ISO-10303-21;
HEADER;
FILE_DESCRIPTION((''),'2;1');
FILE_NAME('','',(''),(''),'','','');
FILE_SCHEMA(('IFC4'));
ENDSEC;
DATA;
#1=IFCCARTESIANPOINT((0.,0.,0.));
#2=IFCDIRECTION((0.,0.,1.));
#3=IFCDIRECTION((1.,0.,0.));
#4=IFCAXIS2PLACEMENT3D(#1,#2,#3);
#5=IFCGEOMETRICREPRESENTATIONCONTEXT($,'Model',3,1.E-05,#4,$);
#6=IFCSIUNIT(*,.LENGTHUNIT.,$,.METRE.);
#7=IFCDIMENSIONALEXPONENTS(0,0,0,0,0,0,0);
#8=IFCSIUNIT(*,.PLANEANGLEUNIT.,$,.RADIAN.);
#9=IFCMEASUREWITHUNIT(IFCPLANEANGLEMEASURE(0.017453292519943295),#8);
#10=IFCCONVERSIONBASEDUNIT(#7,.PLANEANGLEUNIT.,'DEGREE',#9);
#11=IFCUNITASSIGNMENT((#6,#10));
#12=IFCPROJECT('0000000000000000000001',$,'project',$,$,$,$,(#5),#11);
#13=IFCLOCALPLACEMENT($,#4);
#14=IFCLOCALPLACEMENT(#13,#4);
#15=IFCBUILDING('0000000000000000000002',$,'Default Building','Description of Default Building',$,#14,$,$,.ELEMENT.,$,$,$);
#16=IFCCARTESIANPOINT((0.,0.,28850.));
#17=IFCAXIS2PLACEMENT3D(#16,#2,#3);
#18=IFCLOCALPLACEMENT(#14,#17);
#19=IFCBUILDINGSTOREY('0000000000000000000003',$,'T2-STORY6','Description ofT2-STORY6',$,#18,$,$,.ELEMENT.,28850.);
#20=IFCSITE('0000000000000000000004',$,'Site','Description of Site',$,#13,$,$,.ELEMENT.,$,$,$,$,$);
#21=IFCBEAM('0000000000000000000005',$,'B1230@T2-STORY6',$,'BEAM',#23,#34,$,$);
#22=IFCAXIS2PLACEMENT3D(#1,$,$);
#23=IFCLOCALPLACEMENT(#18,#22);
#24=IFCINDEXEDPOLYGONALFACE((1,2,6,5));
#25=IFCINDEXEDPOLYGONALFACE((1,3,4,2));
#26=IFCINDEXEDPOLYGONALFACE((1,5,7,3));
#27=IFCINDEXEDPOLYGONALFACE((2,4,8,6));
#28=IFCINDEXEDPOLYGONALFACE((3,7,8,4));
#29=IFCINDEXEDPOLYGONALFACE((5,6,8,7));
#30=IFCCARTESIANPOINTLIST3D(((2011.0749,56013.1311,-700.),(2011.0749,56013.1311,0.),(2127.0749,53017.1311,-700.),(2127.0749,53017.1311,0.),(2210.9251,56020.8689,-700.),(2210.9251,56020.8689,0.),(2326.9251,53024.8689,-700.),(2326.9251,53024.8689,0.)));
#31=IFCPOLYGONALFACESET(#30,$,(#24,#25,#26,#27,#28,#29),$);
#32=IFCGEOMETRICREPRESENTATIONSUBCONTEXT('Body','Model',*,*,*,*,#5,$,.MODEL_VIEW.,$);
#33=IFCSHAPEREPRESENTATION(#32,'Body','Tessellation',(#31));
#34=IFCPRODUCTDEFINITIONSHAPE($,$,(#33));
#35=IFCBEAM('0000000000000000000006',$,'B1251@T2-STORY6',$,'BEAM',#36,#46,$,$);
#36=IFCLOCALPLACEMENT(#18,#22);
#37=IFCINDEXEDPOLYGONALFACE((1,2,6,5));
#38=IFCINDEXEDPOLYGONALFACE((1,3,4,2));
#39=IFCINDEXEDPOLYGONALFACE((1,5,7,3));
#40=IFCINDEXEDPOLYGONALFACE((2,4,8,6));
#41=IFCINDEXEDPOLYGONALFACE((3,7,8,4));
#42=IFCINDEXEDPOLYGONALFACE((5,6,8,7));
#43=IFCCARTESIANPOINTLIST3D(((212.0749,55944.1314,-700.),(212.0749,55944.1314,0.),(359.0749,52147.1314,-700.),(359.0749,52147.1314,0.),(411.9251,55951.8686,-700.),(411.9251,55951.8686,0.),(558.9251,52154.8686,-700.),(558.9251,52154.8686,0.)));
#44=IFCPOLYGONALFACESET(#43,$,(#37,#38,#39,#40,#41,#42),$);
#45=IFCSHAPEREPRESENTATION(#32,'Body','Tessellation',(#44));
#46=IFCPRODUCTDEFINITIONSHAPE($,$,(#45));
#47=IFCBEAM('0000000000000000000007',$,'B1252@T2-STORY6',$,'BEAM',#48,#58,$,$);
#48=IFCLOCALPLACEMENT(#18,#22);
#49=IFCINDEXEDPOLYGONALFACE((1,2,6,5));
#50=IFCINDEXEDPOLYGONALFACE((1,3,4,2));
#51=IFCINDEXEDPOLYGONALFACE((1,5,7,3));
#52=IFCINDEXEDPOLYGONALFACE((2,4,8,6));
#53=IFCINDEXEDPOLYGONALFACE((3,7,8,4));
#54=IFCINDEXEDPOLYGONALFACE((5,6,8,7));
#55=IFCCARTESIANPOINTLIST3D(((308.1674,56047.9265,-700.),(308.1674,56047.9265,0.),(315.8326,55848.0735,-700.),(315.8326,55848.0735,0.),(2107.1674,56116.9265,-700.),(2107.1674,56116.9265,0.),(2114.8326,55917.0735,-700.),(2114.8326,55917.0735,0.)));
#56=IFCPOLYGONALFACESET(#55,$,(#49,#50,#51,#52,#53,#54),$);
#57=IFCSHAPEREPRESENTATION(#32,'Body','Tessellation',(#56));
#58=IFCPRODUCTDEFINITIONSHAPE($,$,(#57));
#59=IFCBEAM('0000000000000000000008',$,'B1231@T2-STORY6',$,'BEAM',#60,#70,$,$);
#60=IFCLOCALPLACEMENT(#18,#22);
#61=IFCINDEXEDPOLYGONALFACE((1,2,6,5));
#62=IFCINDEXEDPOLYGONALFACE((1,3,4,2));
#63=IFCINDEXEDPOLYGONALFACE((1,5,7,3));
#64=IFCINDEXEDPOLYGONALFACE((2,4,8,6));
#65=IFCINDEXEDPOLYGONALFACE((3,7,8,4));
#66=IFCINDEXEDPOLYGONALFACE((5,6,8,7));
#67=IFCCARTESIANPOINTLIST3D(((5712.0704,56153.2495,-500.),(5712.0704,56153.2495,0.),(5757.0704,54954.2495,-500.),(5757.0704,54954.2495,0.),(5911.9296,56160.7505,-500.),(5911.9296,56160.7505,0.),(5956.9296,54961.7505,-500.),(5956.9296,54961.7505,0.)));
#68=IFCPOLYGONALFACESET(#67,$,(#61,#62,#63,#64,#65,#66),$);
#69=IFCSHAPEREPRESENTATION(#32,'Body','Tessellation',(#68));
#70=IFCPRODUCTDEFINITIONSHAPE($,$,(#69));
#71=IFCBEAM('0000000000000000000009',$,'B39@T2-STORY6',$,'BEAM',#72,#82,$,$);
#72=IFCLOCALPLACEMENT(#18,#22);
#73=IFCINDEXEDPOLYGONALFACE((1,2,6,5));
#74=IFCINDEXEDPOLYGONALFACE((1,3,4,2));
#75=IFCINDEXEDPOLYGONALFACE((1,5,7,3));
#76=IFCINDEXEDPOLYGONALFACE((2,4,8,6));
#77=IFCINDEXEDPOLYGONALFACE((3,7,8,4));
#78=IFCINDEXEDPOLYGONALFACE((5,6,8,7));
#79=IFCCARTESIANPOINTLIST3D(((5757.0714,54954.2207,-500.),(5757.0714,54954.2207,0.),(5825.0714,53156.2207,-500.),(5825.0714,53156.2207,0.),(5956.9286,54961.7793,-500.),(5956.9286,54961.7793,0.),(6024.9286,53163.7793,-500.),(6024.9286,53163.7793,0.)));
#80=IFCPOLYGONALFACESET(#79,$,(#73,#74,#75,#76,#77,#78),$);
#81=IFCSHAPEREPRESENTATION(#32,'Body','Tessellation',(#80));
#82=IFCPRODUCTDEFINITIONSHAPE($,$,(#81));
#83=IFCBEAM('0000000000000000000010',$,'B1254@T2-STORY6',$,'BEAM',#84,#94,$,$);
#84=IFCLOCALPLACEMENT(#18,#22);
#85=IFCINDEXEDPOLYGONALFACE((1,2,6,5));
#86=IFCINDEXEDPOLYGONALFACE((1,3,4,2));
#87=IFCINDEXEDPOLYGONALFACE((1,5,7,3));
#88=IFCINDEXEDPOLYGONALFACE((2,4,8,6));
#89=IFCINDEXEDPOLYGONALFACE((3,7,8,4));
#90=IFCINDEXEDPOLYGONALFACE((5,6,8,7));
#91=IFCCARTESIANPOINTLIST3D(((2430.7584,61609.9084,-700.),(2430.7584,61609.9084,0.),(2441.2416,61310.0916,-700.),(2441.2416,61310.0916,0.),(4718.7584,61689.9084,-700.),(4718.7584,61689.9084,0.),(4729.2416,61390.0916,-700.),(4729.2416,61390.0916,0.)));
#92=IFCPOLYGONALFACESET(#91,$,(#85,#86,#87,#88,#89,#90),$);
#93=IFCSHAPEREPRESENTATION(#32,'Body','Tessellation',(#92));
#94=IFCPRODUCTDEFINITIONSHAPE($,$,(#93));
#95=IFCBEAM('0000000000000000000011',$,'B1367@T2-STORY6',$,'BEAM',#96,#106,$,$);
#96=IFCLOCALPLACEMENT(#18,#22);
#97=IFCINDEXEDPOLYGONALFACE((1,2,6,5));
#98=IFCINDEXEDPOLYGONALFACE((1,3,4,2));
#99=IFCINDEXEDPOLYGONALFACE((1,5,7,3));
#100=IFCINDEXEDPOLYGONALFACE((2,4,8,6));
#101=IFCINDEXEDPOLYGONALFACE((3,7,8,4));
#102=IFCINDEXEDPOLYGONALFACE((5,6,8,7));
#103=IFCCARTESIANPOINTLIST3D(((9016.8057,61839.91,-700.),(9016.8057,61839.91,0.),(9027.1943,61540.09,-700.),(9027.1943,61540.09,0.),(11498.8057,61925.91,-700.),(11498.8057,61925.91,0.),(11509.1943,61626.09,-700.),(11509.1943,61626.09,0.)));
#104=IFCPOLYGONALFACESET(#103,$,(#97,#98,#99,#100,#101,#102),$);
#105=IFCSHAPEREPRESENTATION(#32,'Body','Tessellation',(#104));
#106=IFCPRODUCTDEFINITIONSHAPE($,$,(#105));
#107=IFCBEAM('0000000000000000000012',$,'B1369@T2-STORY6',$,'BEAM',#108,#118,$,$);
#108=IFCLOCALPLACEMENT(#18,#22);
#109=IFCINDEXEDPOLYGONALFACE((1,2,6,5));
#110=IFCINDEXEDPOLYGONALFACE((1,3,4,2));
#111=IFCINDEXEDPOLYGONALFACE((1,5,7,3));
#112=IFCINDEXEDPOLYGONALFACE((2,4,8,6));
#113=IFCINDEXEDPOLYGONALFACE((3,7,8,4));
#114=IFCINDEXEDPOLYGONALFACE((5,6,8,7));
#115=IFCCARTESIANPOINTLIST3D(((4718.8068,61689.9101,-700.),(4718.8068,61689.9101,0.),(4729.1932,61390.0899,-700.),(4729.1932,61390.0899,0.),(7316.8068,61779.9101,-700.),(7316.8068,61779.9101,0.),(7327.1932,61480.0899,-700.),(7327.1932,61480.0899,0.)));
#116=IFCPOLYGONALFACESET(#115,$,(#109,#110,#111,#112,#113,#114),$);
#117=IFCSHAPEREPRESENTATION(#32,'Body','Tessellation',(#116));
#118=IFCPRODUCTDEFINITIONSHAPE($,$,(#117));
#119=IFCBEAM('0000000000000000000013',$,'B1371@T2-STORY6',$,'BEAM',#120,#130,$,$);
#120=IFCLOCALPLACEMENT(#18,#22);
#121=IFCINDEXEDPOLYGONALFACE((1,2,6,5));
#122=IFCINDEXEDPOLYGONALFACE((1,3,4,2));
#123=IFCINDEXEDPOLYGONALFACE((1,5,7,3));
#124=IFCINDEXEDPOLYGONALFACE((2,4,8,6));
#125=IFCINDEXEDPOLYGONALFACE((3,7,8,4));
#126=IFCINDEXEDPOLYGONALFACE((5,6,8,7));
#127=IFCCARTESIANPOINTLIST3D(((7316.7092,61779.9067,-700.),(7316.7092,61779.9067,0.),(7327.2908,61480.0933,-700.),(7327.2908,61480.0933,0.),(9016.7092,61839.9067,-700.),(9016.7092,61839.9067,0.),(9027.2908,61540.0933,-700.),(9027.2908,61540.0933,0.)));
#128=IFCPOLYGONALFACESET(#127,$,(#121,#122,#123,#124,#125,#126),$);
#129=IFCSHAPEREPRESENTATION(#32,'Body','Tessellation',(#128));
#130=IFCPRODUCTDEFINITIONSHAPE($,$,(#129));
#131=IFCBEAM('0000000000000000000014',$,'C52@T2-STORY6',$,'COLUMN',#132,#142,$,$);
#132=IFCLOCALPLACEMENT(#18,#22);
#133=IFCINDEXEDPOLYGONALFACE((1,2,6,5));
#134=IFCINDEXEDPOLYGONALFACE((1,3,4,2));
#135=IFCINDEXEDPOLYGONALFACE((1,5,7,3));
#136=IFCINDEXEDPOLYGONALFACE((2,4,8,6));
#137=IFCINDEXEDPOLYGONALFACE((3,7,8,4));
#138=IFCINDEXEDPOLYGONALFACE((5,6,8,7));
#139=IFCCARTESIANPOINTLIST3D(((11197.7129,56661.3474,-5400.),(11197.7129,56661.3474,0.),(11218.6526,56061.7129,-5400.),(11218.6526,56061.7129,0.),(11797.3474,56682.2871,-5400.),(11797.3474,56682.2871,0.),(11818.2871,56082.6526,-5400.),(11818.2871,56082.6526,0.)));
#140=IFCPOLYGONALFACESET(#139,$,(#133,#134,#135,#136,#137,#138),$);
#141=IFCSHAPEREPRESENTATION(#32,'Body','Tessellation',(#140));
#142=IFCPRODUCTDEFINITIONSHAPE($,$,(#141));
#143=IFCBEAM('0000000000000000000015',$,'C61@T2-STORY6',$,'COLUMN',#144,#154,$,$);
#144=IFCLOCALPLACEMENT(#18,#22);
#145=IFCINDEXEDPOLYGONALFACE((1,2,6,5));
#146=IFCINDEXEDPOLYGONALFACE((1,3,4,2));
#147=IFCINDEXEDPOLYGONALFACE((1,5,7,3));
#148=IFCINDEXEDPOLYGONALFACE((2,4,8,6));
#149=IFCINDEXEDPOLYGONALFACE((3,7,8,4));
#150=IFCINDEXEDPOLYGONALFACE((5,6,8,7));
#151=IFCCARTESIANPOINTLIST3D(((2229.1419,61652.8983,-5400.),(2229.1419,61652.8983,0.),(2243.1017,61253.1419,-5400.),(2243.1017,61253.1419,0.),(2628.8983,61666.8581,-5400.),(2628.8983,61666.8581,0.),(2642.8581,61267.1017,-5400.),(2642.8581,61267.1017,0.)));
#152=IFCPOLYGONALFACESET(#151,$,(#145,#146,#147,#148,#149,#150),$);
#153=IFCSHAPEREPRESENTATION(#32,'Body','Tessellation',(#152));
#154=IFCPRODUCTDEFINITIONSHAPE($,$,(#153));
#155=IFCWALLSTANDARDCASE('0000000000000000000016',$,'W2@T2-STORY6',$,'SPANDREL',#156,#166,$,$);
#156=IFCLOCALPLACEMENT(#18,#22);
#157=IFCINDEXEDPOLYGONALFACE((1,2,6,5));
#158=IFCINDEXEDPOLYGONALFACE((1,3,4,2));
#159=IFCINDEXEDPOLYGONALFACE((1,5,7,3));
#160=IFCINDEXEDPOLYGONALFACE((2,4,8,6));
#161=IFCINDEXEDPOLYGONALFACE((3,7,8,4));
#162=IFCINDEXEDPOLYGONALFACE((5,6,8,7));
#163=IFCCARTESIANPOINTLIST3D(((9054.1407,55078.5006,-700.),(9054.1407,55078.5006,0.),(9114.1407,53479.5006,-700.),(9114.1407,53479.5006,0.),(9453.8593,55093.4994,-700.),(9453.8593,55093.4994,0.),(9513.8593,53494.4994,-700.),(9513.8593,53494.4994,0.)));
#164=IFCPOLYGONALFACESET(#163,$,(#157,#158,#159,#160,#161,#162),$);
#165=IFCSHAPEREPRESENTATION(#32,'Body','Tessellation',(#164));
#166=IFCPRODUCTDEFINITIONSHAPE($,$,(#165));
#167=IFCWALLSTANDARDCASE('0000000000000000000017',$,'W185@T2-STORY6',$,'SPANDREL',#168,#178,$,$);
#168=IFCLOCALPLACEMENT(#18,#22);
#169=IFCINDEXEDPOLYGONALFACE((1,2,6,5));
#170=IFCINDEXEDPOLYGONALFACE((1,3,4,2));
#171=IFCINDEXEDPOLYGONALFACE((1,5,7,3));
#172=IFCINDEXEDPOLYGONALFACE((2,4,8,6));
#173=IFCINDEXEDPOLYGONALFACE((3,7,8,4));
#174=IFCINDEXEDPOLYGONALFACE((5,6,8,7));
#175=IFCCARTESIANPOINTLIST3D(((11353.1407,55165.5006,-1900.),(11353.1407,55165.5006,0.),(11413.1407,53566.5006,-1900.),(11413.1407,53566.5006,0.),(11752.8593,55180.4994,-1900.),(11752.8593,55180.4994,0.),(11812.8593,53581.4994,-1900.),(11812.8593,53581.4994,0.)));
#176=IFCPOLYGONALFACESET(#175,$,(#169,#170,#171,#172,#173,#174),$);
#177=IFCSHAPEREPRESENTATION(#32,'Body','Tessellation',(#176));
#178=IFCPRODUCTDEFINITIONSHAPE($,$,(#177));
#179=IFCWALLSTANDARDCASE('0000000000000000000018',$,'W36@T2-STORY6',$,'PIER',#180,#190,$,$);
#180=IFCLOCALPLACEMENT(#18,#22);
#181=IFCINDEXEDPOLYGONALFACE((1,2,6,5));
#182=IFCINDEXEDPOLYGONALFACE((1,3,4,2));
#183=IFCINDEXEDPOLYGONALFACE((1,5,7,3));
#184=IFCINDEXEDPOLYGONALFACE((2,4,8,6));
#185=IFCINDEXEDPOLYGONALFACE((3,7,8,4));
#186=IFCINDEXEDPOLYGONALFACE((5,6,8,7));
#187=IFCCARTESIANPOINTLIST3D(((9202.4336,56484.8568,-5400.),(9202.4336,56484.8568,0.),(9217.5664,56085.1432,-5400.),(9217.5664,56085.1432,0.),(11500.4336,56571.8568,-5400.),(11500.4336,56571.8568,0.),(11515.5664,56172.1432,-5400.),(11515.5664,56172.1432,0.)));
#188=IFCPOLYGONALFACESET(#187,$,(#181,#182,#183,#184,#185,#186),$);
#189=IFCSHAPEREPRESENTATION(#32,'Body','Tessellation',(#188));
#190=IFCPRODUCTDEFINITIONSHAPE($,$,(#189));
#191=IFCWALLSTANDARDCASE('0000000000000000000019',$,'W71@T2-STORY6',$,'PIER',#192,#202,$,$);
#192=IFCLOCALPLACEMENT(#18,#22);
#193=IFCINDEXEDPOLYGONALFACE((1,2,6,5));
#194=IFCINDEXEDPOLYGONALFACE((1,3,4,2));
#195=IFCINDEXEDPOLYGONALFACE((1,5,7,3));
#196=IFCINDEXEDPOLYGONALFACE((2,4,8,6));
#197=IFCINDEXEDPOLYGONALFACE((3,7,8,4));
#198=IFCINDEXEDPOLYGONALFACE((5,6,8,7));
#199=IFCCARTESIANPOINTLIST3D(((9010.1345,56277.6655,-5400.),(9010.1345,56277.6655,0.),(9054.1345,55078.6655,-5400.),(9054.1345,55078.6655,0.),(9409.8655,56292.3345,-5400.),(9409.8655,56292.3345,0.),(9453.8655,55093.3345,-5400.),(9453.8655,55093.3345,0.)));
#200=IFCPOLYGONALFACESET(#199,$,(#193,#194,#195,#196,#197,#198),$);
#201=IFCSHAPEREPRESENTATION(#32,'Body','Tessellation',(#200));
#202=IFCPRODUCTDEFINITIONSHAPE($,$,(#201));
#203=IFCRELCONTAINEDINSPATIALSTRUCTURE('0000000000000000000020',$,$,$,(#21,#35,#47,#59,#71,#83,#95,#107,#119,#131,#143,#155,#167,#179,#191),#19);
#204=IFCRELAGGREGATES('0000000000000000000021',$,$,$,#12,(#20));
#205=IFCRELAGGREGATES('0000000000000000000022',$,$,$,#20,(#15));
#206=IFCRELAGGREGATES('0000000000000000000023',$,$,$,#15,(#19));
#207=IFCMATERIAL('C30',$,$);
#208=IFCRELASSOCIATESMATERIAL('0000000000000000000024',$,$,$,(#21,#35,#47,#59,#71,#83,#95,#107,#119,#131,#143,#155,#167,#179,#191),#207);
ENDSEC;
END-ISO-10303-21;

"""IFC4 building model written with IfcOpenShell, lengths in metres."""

from ifc_helpers import new_model, entity, si_unit, converted_unit, frame, origin_with_axes, place, context, subcontext, project, spatial, indexed_curve, rectangle, outline, extrude, material, element, save


model = new_model("IFC4")

# Units and contexts
model_context = context("Model", 3, precision=1e-05, world=origin_with_axes())
body_context = subcontext(model_context, "Body", "Model", "MODEL_VIEW")
ifc_project = project(units=[si_unit("LENGTHUNIT", "METRE"), converted_unit("PLANEANGLEUNIT", "DEGREE", entity("IfcPlaneAngleMeasure", 0.017453292519943295), si_unit("PLANEANGLEUNIT", "RADIAN"), dimensions=[0, 0, 0, 0, 0, 0, 0])], contexts=[model_context])

# Site, building, storey
site_placement = place(None, origin_with_axes())
site = spatial("IfcSite", under=ifc_project, at=site_placement, Name="Site", Description="Description of Site", CompositionType="ELEMENT")
building_placement = place(site_placement, origin_with_axes())
building = spatial("IfcBuilding", under=site, at=building_placement, Name="Default Building", Description="Description of Default Building", CompositionType="ELEMENT")
storey_placement = place(building_placement, frame((0.0, 0.0, 28850.0), z_axis=(0.0, 0.0, 1.0), x_axis=(1.0, 0.0, 0.0)))
storey = spatial("IfcBuildingStorey", under=building, at=storey_placement, Name="T2-STORY6", Description="Description ofT2-STORY6", CompositionType="ELEMENT", Elevation=28850.0)

# Beams
ifc_material = material(Name="C30")
beam_1_placement = place(storey_placement, frame((2111.0, 56017.0, -350.0), z_axis=(0.038689, -0.999251, 0.0), x_axis=(0.999251, 0.038689, 0.0)))
element("IfcBeam", 1, at=beam_1_placement, inside=storey, material=ifc_material, Name="B1230@T2-STORY6", ObjectType="BEAM", context=body_context, shape_type="SweptSolid", body=[
    extrude(rectangle(XDim=200.0, YDim=700.0), origin_with_axes(), (0.0, 0.0, 1.0), 2998.2448),
])
beam_2_placement = place(storey_placement, frame((312.0, 55948.0, -350.0), z_axis=(0.038686, -0.999251, 0.0), x_axis=(0.999251, 0.038686, 0.0)))
element("IfcBeam", 2, at=beam_2_placement, inside=storey, material=ifc_material, Name="B1251@T2-STORY6", ObjectType="BEAM", context=body_context, shape_type="SweptSolid", body=[
    extrude(rectangle(XDim=200.0, YDim=700.0), origin_with_axes(), (0.0, 0.0, 1.0), 3799.8445),
])
beam_3_placement = place(storey_placement, frame((312.0, 55948.0, -350.0), z_axis=(0.999265, 0.038326, 0.0), x_axis=(-0.038326, 0.999265, 0.0)))
element("IfcBeam", 3, at=beam_3_placement, inside=storey, material=ifc_material, Name="B1252@T2-STORY6", ObjectType="BEAM", context=body_context, shape_type="SweptSolid", body=[
    extrude(rectangle(XDim=200.0, YDim=700.0), origin_with_axes(), (0.0, 0.0, 1.0), 1800.3227),
])
beam_4_placement = place(storey_placement, frame((5812.0, 56157.0, -250.0), z_axis=(0.037505, -0.999296, 0.0), x_axis=(0.999296, 0.037505, 0.0)))
element("IfcBeam", 4, at=beam_4_placement, inside=storey, material=ifc_material, Name="B1231@T2-STORY6", ObjectType="BEAM", context=body_context, shape_type="SweptSolid", body=[
    extrude(rectangle(XDim=200.0, YDim=500.0), origin_with_axes(), (0.0, 0.0, 1.0), 1199.8442),
])
beam_5_placement = place(storey_placement, frame((5857.0, 54958.0, -250.0), z_axis=(0.037793, -0.999286, 0.0), x_axis=(0.999286, 0.037793, 0.0)))
element("IfcBeam", 5, at=beam_5_placement, inside=storey, material=ifc_material, Name="B39@T2-STORY6", ObjectType="BEAM", context=body_context, shape_type="SweptSolid", body=[
    extrude(rectangle(XDim=200.0, YDim=500.0), origin_with_axes(), (0.0, 0.0, 1.0), 1799.2854),
])
beam_6_placement = place(storey_placement, frame((2436.0, 61460.0, -350.0), z_axis=(0.999389, 0.034944, 0.0), x_axis=(-0.034944, 0.999389, 0.0)))
element("IfcBeam", 6, at=beam_6_placement, inside=storey, material=ifc_material, Name="B1254@T2-STORY6", ObjectType="BEAM", context=body_context, shape_type="SweptSolid", body=[
    extrude(rectangle(XDim=300.0, YDim=700.0), origin_with_axes(), (0.0, 0.0, 1.0), 2289.3982),
])
beam_7_placement = place(storey_placement, frame((9022.0, 61690.0, -350.0), z_axis=(0.9994, 0.034629, 0.0), x_axis=(-0.034629, 0.9994, 0.0)))
element("IfcBeam", 7, at=beam_7_placement, inside=storey, material=ifc_material, Name="B1367@T2-STORY6", ObjectType="BEAM", context=body_context, shape_type="SweptSolid", body=[
    extrude(rectangle(XDim=300.0, YDim=700.0), origin_with_axes(), (0.0, 0.0, 1.0), 2483.4895),
])
beam_8_placement = place(storey_placement, frame((4724.0, 61540.0, -350.0), z_axis=(0.999401, 0.034621, 0.0), x_axis=(-0.034621, 0.999401, 0.0)))
element("IfcBeam", 8, at=beam_8_placement, inside=storey, material=ifc_material, Name="B1369@T2-STORY6", ObjectType="BEAM", context=body_context, shape_type="SweptSolid", body=[
    extrude(rectangle(XDim=300.0, YDim=700.0), origin_with_axes(), (0.0, 0.0, 1.0), 2599.5584),
])
beam_9_placement = place(storey_placement, frame((7322.0, 61630.0, -350.0), z_axis=(0.999378, 0.035272, 0.0), x_axis=(-0.035272, 0.999378, 0.0)))
element("IfcBeam", 9, at=beam_9_placement, inside=storey, material=ifc_material, Name="B1371@T2-STORY6", ObjectType="BEAM", context=body_context, shape_type="SweptSolid", body=[
    extrude(rectangle(XDim=300.0, YDim=700.0), origin_with_axes(), (0.0, 0.0, 1.0), 1701.0585),
])
beam_10_placement = place(storey_placement, frame((11508.0, 56372.0, -5400.0), z_axis=(0.0, 0.0, 1.0), x_axis=(-0.999391, -0.034899, 0.0)))
element("IfcBeam", 10, at=beam_10_placement, inside=storey, material=ifc_material, Name="C52@T2-STORY6", ObjectType="COLUMN", context=body_context, shape_type="SweptSolid", body=[
    extrude(rectangle(XDim=600.0, YDim=600.0), origin_with_axes(), (0.0, 0.0, 1.0), 5400.0),
])
beam_11_placement = place(storey_placement, frame((2436.0, 61460.0, -5400.0), z_axis=(0.0, 0.0, 1.0), x_axis=(-0.999391, -0.034899, 0.0)))
element("IfcBeam", 11, at=beam_11_placement, inside=storey, material=ifc_material, Name="C61@T2-STORY6", ObjectType="COLUMN", context=body_context, shape_type="SweptSolid", body=[
    extrude(rectangle(XDim=400.0, YDim=400.0), origin_with_axes(), (0.0, 0.0, 1.0), 5400.0),
])

# Walls
wall_1_placement = place(storey_placement, frame((9254.0, 55086.0, -700.0), z_axis=(0.0, 0.0, 1.0), x_axis=(0.037497, -0.999297, 0.0)))
element("IfcWallStandardCase", 12, at=wall_1_placement, inside=storey, material=ifc_material, Name="W2@T2-STORY6", ObjectType="SPANDREL", context=body_context, shape_type="SweptSolid", body=[
    extrude(outline(indexed_curve([(0.0, -200.0), (0.0, 200.0), (1600.1253, 200.0), (1600.1253, -200.0), (0.0, -200.0)], self_intersect=False)), origin_with_axes(), (0.0, 0.0, 1.0), 700.0),
])
wall_2_placement = place(storey_placement, frame((11553.0, 55173.0, -1900.0), z_axis=(0.0, 0.0, 1.0), x_axis=(0.037497, -0.999297, 0.0)))
element("IfcWallStandardCase", 13, at=wall_2_placement, inside=storey, material=ifc_material, Name="W185@T2-STORY6", ObjectType="SPANDREL", context=body_context, shape_type="SweptSolid", body=[
    extrude(outline(indexed_curve([(0.0, -200.0), (0.0, 200.0), (1600.1253, 200.0), (1600.1253, -200.0), (0.0, -200.0)], self_intersect=False)), origin_with_axes(), (0.0, 0.0, 1.0), 1900.0),
])
wall_3_placement = place(storey_placement, frame((9210.0, 56285.0, -5400.0), z_axis=(0.0, 0.0, 1.0), x_axis=(0.999284, 0.037832, 0.0)))
element("IfcWallStandardCase", 14, at=wall_3_placement, inside=storey, material=ifc_material, Name="W36@T2-STORY6", ObjectType="PIER", context=body_context, shape_type="SweptSolid", body=[
    extrude(outline(indexed_curve([(0.0, -200.0), (0.0, 200.0), (2299.6463, 200.0), (2299.6463, -200.0), (0.0, -200.0)], self_intersect=False)), origin_with_axes(), (0.0, 0.0, 1.0), 5400.0),
])
wall_4_placement = place(storey_placement, frame((9210.0, 56285.0, -5400.0), z_axis=(0.0, 0.0, 1.0), x_axis=(0.036673, -0.999327, 0.0)))
element("IfcWallStandardCase", 15, at=wall_4_placement, inside=storey, material=ifc_material, Name="W71@T2-STORY6", ObjectType="PIER", context=body_context, shape_type="SweptSolid", body=[
    extrude(outline(indexed_curve([(0.0, -200.0), (0.0, 200.0), (1199.8071, 200.0), (1199.8071, -200.0), (0.0, -200.0)], self_intersect=False)), origin_with_axes(), (0.0, 0.0, 1.0), 5400.0),
])

save(model, "model.ifc")
